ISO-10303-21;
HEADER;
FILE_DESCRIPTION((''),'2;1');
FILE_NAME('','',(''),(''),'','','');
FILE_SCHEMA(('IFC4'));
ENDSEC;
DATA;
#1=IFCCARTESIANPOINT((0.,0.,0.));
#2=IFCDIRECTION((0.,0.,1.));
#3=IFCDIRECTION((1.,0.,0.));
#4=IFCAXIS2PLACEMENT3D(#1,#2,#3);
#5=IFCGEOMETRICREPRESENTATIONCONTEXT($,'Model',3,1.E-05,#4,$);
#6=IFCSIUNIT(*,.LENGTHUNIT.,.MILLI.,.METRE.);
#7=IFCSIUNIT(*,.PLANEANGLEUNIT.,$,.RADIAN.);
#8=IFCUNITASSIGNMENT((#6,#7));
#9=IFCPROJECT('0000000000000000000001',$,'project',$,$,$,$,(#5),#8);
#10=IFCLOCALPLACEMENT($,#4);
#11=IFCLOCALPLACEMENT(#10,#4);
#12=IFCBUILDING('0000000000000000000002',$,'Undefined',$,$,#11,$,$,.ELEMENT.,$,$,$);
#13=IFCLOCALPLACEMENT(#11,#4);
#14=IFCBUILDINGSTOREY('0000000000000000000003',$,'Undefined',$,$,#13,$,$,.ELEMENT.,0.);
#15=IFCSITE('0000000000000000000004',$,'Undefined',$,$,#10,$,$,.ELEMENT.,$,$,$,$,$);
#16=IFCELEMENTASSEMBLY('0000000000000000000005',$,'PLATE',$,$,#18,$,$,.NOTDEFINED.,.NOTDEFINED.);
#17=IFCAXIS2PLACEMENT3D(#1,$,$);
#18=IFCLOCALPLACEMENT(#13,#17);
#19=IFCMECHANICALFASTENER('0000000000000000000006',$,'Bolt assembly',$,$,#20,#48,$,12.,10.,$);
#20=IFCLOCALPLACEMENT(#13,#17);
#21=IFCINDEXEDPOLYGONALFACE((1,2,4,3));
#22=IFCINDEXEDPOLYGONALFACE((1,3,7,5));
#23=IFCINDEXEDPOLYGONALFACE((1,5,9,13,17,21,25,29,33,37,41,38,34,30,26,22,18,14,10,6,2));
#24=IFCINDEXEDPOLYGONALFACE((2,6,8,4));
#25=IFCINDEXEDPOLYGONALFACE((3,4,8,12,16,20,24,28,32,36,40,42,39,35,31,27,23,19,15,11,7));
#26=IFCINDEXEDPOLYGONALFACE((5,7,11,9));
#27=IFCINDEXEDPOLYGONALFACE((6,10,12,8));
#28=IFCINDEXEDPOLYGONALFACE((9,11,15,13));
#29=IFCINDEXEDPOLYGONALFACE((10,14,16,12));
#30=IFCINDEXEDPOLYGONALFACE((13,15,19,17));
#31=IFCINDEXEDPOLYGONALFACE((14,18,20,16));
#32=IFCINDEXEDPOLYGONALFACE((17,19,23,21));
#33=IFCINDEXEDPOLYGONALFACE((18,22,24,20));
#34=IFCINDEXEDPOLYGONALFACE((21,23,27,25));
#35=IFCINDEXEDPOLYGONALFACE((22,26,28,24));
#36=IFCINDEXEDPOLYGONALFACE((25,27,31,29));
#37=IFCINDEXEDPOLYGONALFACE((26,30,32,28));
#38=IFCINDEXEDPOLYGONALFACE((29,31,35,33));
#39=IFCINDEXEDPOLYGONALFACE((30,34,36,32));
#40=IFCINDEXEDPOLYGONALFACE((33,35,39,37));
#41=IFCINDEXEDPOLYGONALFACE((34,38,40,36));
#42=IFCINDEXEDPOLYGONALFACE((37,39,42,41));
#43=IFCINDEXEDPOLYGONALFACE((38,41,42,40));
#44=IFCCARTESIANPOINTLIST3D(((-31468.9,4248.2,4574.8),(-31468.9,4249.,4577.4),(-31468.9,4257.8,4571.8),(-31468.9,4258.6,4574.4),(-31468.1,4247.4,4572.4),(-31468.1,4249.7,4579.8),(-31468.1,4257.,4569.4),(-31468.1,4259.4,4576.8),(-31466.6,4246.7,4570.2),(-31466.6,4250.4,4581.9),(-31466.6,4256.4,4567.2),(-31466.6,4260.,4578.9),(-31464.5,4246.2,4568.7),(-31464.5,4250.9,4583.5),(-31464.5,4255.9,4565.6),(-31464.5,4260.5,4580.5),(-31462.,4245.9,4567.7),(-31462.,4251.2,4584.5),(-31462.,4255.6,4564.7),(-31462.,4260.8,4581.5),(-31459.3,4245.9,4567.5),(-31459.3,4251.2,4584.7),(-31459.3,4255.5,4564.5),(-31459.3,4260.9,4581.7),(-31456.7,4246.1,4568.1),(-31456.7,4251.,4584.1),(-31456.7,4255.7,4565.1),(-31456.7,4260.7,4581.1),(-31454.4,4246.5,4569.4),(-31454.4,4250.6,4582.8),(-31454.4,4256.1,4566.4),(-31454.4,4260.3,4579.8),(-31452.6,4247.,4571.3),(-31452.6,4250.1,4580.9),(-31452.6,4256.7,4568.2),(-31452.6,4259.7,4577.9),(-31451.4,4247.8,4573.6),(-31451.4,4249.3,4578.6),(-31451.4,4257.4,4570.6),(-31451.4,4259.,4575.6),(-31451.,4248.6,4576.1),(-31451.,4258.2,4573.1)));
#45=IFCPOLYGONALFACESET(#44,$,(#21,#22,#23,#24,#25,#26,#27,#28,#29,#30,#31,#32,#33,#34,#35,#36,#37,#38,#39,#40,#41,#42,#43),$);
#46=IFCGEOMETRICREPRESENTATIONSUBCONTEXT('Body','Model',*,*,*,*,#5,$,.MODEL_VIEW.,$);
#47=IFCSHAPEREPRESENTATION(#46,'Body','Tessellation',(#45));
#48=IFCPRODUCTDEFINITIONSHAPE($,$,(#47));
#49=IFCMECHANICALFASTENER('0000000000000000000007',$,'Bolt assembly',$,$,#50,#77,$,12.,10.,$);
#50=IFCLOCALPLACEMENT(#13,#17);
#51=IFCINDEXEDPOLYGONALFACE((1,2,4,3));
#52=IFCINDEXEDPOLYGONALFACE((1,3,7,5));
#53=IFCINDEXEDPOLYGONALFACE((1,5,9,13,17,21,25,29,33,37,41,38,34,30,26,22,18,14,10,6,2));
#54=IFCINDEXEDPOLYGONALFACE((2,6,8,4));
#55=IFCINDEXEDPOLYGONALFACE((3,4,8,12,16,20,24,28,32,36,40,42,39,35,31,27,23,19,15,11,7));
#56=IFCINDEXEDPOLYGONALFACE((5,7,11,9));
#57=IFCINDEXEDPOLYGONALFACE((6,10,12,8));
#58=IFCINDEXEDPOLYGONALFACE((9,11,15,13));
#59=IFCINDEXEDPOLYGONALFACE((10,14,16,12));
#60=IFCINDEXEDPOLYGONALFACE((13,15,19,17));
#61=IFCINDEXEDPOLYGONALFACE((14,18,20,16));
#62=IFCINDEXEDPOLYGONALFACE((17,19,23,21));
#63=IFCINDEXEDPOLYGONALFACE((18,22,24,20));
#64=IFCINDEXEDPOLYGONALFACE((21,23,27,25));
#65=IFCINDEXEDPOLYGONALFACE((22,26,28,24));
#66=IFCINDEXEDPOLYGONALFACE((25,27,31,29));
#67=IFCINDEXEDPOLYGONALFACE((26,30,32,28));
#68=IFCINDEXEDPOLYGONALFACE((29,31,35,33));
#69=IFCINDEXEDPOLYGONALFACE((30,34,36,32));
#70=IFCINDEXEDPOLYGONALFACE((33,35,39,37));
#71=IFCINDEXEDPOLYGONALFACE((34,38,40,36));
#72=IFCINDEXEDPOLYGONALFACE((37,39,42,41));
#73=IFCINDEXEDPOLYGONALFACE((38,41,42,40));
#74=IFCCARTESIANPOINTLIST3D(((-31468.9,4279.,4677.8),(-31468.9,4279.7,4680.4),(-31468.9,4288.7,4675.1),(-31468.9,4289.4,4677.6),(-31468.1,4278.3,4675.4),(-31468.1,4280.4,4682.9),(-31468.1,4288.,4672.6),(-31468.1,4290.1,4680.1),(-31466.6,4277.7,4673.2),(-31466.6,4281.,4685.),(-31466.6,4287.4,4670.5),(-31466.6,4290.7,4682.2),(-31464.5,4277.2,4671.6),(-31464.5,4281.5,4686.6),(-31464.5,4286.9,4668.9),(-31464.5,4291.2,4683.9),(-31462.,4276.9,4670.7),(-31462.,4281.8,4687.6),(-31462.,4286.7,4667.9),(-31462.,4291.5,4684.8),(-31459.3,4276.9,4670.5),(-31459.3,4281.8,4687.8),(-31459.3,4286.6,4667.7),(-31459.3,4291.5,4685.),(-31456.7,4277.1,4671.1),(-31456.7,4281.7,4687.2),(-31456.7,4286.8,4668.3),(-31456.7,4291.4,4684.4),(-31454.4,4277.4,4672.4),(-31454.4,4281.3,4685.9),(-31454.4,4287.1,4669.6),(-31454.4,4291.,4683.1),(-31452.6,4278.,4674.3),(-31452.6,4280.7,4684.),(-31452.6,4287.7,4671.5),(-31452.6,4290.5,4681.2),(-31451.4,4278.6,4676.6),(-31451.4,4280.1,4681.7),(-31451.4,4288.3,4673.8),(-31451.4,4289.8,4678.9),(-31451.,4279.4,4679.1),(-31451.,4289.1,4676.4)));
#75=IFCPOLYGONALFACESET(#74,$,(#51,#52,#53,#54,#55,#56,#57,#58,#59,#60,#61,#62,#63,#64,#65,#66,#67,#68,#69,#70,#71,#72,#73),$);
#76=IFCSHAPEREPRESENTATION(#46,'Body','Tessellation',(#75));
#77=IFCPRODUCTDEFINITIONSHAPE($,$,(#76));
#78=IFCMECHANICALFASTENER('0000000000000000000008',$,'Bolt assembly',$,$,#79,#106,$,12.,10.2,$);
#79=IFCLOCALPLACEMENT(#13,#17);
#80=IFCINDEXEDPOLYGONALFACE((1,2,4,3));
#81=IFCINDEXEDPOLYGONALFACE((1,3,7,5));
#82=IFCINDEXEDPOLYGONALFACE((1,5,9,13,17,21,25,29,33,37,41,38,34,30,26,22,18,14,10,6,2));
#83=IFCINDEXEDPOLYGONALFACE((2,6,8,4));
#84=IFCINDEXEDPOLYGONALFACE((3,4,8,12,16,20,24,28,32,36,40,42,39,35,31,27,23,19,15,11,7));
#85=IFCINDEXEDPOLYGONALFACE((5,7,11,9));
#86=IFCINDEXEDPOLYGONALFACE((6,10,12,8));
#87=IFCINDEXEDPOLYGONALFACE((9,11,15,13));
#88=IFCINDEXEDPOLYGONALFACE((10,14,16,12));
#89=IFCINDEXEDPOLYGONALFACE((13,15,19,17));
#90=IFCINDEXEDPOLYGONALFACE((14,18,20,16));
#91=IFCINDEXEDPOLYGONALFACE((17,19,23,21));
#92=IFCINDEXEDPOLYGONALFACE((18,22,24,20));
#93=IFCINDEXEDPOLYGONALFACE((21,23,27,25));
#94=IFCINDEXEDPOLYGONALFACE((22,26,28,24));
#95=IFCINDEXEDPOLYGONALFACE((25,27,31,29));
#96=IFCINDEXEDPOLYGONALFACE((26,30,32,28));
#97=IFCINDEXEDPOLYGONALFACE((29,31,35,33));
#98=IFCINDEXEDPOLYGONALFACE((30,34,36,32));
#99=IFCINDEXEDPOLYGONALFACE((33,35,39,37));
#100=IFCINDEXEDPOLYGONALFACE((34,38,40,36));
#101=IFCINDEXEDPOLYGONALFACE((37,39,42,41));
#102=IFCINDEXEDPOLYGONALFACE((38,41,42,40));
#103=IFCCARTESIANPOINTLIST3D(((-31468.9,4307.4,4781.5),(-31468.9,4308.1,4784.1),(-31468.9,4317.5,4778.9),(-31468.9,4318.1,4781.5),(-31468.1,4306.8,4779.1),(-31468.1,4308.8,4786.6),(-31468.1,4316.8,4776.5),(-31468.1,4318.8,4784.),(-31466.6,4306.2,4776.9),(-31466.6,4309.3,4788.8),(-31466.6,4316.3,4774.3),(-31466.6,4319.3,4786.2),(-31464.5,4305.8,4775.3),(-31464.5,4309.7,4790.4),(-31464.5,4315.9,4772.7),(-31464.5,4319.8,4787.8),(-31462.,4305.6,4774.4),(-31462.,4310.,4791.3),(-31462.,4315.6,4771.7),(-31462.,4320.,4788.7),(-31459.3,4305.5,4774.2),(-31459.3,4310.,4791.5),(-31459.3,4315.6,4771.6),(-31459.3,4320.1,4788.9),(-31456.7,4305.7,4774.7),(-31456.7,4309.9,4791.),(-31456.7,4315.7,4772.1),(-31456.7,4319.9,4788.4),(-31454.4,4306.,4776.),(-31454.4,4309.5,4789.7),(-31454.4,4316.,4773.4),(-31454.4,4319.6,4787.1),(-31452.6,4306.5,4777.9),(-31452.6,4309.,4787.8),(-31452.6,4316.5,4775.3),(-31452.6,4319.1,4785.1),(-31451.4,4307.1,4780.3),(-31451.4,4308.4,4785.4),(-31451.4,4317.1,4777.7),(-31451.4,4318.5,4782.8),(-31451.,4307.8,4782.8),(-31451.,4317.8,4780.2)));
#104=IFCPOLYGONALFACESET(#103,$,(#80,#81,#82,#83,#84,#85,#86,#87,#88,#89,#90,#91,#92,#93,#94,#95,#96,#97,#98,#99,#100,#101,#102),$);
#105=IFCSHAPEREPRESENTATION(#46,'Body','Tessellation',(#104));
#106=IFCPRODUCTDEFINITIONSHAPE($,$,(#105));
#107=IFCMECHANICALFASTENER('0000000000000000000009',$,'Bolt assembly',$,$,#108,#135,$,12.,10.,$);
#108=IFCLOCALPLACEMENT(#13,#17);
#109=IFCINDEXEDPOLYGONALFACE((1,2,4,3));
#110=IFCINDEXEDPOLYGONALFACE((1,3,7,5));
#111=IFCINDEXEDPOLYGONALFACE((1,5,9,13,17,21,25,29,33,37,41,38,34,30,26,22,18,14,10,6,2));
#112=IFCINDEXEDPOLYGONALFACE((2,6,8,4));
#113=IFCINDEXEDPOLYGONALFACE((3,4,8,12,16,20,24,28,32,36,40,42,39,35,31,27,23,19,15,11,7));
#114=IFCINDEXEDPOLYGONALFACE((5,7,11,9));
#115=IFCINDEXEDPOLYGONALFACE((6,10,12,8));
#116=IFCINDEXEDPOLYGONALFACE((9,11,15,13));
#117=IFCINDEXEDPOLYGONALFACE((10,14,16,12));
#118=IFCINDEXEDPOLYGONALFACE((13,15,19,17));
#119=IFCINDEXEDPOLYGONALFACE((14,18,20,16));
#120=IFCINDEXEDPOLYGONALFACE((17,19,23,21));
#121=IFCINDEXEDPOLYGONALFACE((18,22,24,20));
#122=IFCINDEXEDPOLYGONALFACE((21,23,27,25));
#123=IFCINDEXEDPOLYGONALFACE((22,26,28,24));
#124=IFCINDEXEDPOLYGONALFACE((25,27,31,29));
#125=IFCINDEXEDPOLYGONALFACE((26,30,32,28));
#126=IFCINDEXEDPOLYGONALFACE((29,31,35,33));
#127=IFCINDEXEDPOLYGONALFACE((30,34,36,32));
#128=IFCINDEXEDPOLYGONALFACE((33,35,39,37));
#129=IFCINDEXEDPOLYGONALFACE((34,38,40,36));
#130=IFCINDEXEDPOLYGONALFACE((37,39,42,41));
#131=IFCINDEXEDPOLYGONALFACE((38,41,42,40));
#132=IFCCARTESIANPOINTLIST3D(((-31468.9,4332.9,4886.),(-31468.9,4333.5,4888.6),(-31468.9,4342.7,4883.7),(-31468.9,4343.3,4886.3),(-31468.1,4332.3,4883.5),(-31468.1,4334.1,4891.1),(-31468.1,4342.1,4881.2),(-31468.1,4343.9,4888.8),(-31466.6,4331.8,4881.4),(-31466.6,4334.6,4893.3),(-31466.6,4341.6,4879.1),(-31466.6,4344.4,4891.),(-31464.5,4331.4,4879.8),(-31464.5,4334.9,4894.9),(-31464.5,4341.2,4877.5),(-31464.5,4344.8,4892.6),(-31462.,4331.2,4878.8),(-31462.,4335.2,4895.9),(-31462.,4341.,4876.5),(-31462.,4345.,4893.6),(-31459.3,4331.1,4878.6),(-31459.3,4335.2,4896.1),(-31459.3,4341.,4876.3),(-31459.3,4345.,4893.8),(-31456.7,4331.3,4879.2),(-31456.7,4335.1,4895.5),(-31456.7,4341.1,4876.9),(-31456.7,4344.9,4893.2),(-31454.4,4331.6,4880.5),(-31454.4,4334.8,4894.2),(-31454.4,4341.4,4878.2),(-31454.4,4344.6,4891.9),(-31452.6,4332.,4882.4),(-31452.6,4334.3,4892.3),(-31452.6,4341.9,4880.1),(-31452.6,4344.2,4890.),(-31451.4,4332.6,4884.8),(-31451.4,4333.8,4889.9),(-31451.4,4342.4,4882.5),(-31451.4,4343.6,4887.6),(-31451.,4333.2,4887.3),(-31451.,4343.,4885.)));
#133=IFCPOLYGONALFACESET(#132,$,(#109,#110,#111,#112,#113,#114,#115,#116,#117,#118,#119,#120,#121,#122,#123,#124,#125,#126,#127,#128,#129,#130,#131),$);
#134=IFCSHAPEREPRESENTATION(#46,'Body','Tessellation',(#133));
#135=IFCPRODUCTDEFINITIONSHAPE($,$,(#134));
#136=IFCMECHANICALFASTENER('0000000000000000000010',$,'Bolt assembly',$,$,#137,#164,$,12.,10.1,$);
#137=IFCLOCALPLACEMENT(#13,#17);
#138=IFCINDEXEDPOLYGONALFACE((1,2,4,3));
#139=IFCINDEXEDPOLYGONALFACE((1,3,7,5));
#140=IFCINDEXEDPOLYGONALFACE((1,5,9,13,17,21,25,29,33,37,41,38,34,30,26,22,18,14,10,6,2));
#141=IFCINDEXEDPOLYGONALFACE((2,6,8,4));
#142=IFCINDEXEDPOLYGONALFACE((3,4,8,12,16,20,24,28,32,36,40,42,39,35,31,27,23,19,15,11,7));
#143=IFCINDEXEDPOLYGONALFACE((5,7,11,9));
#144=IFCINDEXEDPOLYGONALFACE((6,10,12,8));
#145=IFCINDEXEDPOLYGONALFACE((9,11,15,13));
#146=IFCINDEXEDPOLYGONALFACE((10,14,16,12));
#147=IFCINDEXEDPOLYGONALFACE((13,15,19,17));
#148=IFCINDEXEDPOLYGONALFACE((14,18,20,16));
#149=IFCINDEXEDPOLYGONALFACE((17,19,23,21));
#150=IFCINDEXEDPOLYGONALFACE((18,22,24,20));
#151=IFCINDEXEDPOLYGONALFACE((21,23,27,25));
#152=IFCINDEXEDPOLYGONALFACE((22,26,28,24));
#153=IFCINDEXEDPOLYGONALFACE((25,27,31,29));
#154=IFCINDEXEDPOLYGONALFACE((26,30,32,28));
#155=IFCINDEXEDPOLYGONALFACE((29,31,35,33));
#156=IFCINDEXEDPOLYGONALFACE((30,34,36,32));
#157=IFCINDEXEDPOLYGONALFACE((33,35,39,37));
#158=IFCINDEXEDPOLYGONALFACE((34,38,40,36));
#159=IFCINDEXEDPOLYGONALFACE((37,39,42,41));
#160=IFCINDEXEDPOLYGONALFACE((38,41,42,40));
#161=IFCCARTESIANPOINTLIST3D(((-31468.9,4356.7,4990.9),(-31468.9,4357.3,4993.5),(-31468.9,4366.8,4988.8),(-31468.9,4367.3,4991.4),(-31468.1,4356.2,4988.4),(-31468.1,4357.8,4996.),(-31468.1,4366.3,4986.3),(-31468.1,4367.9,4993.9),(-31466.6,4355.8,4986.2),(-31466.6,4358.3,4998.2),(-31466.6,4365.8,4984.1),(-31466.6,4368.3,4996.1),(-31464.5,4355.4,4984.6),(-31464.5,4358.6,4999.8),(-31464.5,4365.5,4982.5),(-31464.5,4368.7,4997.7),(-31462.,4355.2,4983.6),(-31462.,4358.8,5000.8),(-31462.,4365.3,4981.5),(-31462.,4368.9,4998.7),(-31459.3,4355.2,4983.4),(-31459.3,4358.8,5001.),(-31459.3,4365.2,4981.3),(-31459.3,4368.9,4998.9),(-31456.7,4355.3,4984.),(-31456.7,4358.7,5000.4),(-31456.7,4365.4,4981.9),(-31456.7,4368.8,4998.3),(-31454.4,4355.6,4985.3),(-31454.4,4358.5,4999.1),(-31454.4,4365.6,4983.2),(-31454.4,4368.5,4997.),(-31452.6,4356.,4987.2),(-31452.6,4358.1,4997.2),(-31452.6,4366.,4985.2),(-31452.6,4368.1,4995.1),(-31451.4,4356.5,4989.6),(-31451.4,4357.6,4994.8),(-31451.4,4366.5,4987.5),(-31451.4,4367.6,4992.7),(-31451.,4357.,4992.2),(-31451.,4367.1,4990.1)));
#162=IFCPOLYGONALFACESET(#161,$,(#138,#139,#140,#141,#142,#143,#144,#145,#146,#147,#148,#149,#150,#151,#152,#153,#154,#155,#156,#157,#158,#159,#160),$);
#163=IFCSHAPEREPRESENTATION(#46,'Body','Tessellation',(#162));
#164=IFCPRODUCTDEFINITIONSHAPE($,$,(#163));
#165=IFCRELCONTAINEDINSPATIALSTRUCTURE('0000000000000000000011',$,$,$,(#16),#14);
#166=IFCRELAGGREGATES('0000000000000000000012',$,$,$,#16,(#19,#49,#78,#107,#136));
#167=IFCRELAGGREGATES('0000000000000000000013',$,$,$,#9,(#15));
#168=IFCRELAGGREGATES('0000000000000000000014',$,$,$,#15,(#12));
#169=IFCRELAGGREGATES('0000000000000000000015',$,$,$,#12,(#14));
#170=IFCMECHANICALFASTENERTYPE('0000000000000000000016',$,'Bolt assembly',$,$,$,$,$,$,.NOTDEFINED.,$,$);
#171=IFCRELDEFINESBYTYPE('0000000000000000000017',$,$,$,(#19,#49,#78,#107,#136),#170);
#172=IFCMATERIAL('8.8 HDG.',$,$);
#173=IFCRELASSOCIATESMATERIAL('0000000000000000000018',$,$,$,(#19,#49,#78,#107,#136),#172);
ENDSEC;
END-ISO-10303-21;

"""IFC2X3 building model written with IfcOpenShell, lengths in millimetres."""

from ifc_helpers import new_model, si_unit, frame, origin_with_axes, origin_2d_with_axis, place, context, subcontext, project, spatial, circle, extrude, source, transform, mapped, material, type_object, element, aggregate, save


model = new_model("IFC2X3")

# Units and contexts
model_context = context("Model", 3, precision=1e-05, world=origin_with_axes())
body_context = subcontext(model_context, "Body", "Model", "MODEL_VIEW")
ifc_project = project(units=[si_unit("LENGTHUNIT", "METRE", prefix="MILLI"), si_unit("PLANEANGLEUNIT", "RADIAN")], contexts=[model_context])

# Site, building, storey
site_placement = place(None, origin_with_axes())
site = spatial("IfcSite", under=ifc_project, at=site_placement, Name="Undefined", CompositionType="ELEMENT")
building_placement = place(site_placement, origin_with_axes())
building = spatial("IfcBuilding", under=site, at=building_placement, Name="Undefined", CompositionType="ELEMENT")
storey_placement = place(building_placement, origin_with_axes())
storey = spatial("IfcBuildingStorey", under=building, at=storey_placement, Name="Undefined", CompositionType="ELEMENT", Elevation=0.0)

# Element assembly, mechanical fasteners
assembly_placement = place(storey_placement, origin_with_axes())
assembly = element("IfcElementAssembly", 1, at=assembly_placement, inside=storey, Name="PLATE", AssemblyPlace="NOTDEFINED", PredefinedType="NOTDEFINED")
ifc_material_1 = material(Name="8.8 HDG.")
mechanical_fastener_type = type_object("IfcMechanicalFastenerType", Name="Bolt assembly")
shared_shape_1 = source(origin_with_axes(), body_context, "Body", "SweptSolid", [
    extrude(circle(Radius=9.0, at=origin_2d_with_axis()), frame((0.0, 0.8, 0.0), z_axis=(0.0, 1.0, 0.0), x_axis=(1.0, 0.0, 0.0)), (0.0, 0.0, 1.0), 10.1),
])
mechanical_fastener_1_placement = place(assembly_placement, frame((-31460.0, 4259.0, 4572.9), z_axis=(0.000001, -0.297503, -0.954721), x_axis=(1.0, 0.000001, 0.000001)))
mechanical_fastener_1 = element("IfcMechanicalFastener", 2, at=mechanical_fastener_1_placement, type_object=mechanical_fastener_type, material=ifc_material_1, Name="Bolt assembly", NominalDiameter=12.0, NominalLength=10.0, context=body_context, shape_type="MappedRepresentation", body=[
    mapped(shared_shape_1, transform((0.0, 0.0, 0.0))),
])
shared_shape_2 = source(origin_with_axes(), body_context, "Body", "SweptSolid", [
    extrude(circle(Radius=9.0, at=origin_2d_with_axis()), frame((0.0, 0.7, 0.0), z_axis=(0.0, 1.0, 0.0), x_axis=(1.0, 0.0, 0.0)), (0.0, 0.0, 1.0), 10.1),
])
mechanical_fastener_2_placement = place(assembly_placement, frame((-31460.0, 4289.8, 4676.2), z_axis=(0.000001, -0.274347, -0.961631), x_axis=(1.0, 0.000001, 0.000001)))
mechanical_fastener_2 = element("IfcMechanicalFastener", 3, at=mechanical_fastener_2_placement, type_object=mechanical_fastener_type, material=ifc_material_1, Name="Bolt assembly", NominalDiameter=12.0, NominalLength=10.0, context=body_context, shape_type="MappedRepresentation", body=[
    mapped(shared_shape_2, transform((0.0, 0.0, 0.0))),
])
shared_shape_3 = source(origin_with_axes(), body_context, "Body", "SweptSolid", [
    extrude(circle(Radius=9.0, at=origin_2d_with_axis()), frame((0.0, 0.3, 0.0), z_axis=(0.0, 1.0, 0.0), x_axis=(1.0, 0.0, 0.0)), (0.0, 0.0, 1.0), 10.4),
])
mechanical_fastener_3_placement = place(assembly_placement, frame((-31460.0, 4318.1, 4780.2), z_axis=(0.000001, -0.25103, -0.967979), x_axis=(1.0, 0.000001, 0.000001)))
mechanical_fastener_3 = element("IfcMechanicalFastener", 4, at=mechanical_fastener_3_placement, type_object=mechanical_fastener_type, material=ifc_material_1, Name="Bolt assembly", NominalDiameter=12.0, NominalLength=10.2, context=body_context, shape_type="MappedRepresentation", body=[
    mapped(shared_shape_3, transform((0.0, 0.0, 0.0))),
])
shared_shape_4 = source(origin_with_axes(), body_context, "Body", "SweptSolid", [
    extrude(circle(Radius=9.0, at=origin_2d_with_axis()), frame((0.0, 0.9, 0.0), z_axis=(0.0, 1.0, 0.0), x_axis=(1.0, 0.0, 0.0)), (0.0, 0.0, 1.0), 10.1),
])
mechanical_fastener_4_placement = place(assembly_placement, frame((-31460.0, 4343.9, 4884.8), z_axis=(0.000001, -0.227567, -0.973763), x_axis=(1.0, 0.000001, 0.000001)))
mechanical_fastener_4 = element("IfcMechanicalFastener", 5, at=mechanical_fastener_4_placement, type_object=mechanical_fastener_type, material=ifc_material_1, Name="Bolt assembly", NominalDiameter=12.0, NominalLength=10.0, context=body_context, shape_type="MappedRepresentation", body=[
    mapped(shared_shape_4, transform((0.0, 0.0, 0.0))),
])
shared_shape_5 = source(origin_with_axes(), body_context, "Body", "SweptSolid", [
    extrude(circle(Radius=9.0, at=origin_2d_with_axis()), frame((0.0, 0.1, 0.0), z_axis=(0.0, 1.0, 0.0), x_axis=(1.0, 0.0, 0.0)), (0.0, 0.0, 1.0), 10.3),
])
mechanical_fastener_5_placement = place(assembly_placement, frame((-31460.0, 4367.2, 4990.1), z_axis=(0.000001, -0.20397, -0.978977), x_axis=(1.0, 0.000001, 0.000001)))
mechanical_fastener_5 = element("IfcMechanicalFastener", 6, at=mechanical_fastener_5_placement, type_object=mechanical_fastener_type, material=ifc_material_1, Name="Bolt assembly", NominalDiameter=12.0, NominalLength=10.1, context=body_context, shape_type="MappedRepresentation", body=[
    mapped(shared_shape_5, transform((0.0, 0.0, 0.0))),
])
aggregate(assembly, [mechanical_fastener_1, mechanical_fastener_2, mechanical_fastener_3, mechanical_fastener_4, mechanical_fastener_5])

save(model, "model.ifc")
